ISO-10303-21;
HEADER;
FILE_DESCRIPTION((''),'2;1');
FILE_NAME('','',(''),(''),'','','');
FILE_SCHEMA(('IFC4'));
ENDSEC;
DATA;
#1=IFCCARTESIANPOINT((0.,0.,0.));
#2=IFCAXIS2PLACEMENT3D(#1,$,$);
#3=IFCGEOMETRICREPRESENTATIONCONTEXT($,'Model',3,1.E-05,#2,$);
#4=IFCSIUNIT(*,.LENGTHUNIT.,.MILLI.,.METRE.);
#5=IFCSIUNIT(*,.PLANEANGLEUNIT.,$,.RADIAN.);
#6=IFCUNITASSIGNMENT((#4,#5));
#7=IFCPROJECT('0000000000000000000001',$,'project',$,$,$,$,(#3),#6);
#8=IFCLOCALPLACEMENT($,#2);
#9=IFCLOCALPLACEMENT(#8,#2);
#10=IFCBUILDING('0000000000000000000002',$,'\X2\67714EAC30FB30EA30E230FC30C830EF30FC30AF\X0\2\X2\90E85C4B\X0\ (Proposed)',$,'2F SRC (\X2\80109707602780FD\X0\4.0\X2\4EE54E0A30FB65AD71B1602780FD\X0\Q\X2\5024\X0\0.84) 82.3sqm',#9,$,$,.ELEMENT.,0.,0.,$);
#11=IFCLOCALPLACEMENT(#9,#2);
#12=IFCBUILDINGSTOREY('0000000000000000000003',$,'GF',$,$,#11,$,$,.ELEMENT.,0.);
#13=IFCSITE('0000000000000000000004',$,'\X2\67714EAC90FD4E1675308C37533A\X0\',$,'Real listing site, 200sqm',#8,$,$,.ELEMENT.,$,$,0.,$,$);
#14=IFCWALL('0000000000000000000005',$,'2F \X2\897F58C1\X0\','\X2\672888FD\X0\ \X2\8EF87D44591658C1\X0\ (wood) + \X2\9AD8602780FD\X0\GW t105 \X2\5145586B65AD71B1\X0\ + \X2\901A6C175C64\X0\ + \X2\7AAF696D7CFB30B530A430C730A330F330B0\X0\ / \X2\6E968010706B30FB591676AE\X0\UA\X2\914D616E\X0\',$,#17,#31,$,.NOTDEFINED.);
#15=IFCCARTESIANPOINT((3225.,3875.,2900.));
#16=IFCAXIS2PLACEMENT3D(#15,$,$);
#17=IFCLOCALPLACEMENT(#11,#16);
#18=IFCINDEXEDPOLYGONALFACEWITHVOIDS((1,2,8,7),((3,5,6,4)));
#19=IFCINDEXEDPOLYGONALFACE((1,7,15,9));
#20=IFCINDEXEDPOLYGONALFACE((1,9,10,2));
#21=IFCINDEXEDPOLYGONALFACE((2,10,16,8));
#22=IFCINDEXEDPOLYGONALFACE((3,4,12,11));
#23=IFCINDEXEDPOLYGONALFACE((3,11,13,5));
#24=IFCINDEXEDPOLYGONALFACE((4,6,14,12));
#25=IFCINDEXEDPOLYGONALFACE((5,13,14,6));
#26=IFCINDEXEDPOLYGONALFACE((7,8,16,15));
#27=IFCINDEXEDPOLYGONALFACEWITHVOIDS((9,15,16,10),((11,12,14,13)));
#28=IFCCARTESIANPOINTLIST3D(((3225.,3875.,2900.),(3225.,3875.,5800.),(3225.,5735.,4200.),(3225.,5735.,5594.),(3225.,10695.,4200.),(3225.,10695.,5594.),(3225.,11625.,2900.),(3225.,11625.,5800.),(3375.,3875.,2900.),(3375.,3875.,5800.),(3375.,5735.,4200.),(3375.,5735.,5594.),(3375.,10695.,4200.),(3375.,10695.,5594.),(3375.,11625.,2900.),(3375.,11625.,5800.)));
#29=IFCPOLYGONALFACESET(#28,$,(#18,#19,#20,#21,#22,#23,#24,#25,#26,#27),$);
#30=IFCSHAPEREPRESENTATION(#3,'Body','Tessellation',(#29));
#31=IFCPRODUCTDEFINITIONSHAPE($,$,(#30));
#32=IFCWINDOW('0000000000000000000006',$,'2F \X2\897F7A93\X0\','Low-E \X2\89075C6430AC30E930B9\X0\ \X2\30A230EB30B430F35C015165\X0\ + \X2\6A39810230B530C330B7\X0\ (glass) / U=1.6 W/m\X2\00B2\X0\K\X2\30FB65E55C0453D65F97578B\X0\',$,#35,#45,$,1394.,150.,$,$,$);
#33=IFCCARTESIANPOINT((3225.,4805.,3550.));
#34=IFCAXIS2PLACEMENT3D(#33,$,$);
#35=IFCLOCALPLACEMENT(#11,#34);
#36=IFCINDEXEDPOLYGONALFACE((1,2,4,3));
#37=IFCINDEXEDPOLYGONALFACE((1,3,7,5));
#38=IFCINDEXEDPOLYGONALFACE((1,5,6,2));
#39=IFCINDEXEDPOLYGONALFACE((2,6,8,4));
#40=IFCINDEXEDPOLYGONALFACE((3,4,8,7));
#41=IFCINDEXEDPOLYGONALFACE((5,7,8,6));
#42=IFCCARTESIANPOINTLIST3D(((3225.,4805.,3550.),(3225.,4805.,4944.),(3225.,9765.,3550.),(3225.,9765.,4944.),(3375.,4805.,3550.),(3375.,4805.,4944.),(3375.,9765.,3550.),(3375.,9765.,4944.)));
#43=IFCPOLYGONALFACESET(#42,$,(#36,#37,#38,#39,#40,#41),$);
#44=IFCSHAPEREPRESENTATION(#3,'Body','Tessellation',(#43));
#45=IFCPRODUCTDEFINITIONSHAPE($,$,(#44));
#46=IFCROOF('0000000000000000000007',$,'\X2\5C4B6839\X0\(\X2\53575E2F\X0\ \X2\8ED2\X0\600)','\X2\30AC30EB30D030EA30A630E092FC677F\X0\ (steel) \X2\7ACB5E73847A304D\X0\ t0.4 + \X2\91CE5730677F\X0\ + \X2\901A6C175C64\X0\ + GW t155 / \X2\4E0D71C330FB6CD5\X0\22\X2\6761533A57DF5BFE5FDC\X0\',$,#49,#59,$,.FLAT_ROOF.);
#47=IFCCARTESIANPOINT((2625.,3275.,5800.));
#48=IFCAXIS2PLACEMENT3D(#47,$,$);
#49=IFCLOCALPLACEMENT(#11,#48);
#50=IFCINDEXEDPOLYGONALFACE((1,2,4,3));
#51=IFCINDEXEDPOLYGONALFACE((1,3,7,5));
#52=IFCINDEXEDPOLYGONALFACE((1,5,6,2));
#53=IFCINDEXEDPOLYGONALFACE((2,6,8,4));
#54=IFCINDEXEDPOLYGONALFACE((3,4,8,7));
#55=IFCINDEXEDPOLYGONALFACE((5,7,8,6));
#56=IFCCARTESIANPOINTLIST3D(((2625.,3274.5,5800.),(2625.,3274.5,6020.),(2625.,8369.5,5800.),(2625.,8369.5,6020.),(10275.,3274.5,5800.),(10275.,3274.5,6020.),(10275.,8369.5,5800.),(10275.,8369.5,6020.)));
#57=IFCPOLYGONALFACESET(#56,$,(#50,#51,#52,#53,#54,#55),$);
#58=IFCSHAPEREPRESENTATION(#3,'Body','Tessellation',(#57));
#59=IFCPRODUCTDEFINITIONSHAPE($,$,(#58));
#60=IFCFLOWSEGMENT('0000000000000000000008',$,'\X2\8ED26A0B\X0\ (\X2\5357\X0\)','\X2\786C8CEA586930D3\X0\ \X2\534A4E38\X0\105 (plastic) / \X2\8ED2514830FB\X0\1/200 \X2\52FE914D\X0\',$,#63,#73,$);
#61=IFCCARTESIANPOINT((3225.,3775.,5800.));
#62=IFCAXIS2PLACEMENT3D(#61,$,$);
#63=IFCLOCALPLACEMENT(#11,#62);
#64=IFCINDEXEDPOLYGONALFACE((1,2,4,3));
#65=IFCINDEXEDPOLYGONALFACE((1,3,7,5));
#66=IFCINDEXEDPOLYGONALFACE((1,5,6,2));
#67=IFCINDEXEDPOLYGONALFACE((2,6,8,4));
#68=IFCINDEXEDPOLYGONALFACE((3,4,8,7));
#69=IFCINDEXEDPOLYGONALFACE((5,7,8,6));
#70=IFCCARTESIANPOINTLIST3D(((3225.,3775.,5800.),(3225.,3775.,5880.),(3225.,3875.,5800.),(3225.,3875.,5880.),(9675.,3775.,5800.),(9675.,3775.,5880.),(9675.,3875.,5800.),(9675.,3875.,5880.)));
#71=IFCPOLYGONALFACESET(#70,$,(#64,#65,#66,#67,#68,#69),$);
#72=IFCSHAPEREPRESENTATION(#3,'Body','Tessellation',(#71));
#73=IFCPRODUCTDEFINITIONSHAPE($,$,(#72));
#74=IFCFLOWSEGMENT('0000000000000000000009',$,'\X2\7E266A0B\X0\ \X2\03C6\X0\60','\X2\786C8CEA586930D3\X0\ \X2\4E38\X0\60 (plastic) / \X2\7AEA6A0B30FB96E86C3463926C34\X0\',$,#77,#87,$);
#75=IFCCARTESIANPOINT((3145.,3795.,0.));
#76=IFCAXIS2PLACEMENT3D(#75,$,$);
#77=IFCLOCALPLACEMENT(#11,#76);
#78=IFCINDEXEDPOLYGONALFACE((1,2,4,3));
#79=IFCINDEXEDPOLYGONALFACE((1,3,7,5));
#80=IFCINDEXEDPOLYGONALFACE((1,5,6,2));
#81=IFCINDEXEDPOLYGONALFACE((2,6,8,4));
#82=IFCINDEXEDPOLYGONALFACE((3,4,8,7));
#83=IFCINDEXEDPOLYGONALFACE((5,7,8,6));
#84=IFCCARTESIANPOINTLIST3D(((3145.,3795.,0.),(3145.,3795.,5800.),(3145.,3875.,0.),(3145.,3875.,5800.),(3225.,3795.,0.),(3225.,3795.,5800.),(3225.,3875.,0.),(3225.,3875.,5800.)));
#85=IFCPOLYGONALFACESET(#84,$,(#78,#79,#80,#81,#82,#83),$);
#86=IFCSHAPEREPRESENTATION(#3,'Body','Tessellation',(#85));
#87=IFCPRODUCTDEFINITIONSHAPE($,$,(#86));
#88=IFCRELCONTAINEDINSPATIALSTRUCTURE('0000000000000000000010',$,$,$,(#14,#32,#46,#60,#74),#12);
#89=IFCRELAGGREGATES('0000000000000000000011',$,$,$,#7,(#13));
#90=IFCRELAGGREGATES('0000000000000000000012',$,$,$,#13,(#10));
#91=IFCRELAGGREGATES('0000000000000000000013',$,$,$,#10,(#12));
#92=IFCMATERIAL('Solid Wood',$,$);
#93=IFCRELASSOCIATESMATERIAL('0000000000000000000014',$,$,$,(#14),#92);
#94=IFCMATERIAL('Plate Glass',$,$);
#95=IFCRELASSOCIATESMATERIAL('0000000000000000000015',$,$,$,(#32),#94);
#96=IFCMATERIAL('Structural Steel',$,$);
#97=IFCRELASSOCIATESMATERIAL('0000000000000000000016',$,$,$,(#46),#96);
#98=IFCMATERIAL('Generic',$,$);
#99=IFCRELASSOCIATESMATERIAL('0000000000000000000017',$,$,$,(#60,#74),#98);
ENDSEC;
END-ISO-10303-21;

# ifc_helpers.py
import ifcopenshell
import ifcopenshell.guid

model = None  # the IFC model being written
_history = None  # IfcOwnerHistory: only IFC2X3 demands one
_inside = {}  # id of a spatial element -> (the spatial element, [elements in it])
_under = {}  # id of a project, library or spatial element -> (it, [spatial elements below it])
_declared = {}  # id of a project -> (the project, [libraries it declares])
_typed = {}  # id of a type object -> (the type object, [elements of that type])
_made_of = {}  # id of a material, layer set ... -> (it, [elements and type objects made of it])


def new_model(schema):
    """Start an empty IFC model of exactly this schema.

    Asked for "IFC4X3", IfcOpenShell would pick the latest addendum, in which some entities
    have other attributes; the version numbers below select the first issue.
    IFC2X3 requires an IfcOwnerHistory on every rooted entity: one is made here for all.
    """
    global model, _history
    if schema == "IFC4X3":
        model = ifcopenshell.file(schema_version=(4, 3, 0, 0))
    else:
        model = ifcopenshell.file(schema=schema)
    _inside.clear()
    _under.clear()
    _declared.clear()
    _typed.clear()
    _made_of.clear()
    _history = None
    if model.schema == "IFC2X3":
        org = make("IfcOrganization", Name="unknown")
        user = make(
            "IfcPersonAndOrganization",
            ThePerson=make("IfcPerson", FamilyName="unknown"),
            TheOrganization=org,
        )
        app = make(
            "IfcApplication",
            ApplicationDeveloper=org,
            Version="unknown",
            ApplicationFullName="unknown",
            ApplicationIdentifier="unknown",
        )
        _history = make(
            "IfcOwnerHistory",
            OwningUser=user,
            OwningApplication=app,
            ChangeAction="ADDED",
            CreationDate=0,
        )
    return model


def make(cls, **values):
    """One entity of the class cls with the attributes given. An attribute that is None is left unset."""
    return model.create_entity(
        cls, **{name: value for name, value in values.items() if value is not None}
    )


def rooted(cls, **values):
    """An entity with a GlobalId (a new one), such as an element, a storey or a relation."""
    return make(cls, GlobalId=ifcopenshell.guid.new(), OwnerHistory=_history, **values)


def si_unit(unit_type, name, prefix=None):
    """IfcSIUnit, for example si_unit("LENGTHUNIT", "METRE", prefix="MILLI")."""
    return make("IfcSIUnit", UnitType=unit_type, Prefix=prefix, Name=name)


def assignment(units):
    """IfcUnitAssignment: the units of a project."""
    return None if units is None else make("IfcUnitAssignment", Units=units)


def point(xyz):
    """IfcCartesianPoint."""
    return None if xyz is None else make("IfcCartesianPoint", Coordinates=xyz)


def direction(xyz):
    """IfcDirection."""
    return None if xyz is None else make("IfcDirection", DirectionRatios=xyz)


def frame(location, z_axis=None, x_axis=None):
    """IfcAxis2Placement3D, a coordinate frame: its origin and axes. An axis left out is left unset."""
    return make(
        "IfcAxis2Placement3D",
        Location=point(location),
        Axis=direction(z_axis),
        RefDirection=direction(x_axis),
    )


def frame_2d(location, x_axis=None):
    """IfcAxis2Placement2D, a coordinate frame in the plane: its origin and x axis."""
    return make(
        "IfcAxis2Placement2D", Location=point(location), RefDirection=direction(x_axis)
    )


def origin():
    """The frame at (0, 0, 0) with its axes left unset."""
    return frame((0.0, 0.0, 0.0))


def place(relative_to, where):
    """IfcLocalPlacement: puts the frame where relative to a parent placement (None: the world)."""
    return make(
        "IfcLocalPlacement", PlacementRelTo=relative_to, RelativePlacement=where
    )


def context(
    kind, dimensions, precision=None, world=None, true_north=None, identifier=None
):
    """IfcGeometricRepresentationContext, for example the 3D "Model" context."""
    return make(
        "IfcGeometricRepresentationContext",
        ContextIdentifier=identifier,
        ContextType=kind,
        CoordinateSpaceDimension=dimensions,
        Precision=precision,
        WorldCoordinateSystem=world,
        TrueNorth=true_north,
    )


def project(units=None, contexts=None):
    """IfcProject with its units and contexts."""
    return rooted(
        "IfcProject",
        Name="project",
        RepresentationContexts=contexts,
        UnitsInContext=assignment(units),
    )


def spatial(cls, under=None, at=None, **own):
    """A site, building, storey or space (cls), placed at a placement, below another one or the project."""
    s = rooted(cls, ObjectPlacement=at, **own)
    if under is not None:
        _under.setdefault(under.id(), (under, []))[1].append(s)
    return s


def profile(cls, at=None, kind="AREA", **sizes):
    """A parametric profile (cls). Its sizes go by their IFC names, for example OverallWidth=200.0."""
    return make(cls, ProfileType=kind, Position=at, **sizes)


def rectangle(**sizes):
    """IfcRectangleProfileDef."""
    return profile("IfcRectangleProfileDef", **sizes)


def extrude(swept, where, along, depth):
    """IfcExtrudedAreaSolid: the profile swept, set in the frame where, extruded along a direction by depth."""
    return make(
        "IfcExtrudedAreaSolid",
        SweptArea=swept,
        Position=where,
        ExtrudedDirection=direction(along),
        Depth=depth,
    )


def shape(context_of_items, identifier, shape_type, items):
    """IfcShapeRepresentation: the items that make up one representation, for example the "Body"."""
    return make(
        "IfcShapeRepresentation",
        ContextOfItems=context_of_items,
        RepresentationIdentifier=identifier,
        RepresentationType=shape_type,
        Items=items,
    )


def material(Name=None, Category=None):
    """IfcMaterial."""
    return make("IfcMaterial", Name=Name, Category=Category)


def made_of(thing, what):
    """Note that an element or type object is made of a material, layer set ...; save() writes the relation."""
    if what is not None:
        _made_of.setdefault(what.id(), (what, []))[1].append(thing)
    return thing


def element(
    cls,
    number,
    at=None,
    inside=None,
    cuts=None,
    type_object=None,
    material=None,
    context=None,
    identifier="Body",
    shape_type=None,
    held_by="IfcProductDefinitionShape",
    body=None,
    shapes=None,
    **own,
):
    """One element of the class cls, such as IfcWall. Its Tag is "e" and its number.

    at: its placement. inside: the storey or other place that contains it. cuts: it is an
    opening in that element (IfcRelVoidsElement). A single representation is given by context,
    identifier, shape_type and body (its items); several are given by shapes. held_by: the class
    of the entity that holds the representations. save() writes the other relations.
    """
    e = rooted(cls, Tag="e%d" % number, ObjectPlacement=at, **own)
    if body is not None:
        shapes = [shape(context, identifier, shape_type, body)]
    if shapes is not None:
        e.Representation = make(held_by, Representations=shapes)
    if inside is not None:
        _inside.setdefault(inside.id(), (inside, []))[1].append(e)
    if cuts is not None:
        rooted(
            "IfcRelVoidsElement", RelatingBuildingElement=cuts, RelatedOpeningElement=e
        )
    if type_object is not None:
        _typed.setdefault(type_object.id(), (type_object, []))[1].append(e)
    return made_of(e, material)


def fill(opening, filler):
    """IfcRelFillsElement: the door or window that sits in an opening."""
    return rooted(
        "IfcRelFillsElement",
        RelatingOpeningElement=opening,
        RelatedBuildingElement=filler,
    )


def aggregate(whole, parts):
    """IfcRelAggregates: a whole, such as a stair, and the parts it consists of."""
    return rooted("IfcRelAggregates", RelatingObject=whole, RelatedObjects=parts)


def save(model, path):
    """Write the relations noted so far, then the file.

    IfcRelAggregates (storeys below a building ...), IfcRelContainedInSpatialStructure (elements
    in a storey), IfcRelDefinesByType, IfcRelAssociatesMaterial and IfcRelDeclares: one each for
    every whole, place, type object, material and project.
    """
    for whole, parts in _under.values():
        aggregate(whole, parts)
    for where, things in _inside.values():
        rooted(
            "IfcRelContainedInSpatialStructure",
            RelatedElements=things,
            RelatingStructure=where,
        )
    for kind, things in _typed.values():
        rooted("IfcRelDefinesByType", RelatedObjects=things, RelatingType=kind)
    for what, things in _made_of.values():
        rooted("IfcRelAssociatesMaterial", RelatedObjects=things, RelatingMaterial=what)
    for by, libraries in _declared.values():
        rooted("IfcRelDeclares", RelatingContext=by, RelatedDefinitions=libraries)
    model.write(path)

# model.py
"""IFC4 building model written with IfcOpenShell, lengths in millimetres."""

from ifc_helpers import new_model, si_unit, frame, frame_2d, origin, place, context, project, spatial, rectangle, extrude, material, element, fill, save


model = new_model("IFC4")

# Units and contexts
model_context = context("Model", 3, precision=1e-05, world=origin())
ifc_project = project(units=[si_unit("LENGTHUNIT", "METRE", prefix="MILLI"), si_unit("PLANEANGLEUNIT", "RADIAN")], contexts=[model_context])

# Site, building, storey
site_placement = place(None, origin())
site = spatial("IfcSite", under=ifc_project, at=site_placement, Name="東京都世田谷区", ObjectType="Real listing site, 200sqm", CompositionType="ELEMENT", RefElevation=0.0)
building_placement = place(site_placement, origin())
building = spatial("IfcBuilding", under=site, at=building_placement, Name="東京・リモートワーク2部屋 (Proposed)", ObjectType="2F SRC (耐震性能4.0以上・断熱性能Q値0.84) 82.3sqm", CompositionType="ELEMENT", ElevationOfRefHeight=0.0, ElevationOfTerrain=0.0)
storey_placement = place(building_placement, origin())
storey = spatial("IfcBuildingStorey", under=building, at=storey_placement, Name="GF", CompositionType="ELEMENT", Elevation=0.0)

# Shared definitions
ifc_material_1 = material(Name="Solid Wood")

# Shared definitions
ifc_material_2 = material(Name="Plate Glass")

# Wall, opening, window
wall_1_placement = place(storey_placement, frame((3225.0, 3875.0, 2900.0)))
wall_1 = element("IfcWall", 1, at=wall_1_placement, inside=storey, material=ifc_material_1, Name="2F 西壁", Description="木製 軸組外壁 (wood) + 高性能GW t105 充填断熱 + 通気層 + 窯業系サイディング / 準耐火・外皮UA配慮", PredefinedType="NOTDEFINED", context=model_context, shape_type="SweptSolid", body=[
    extrude(rectangle(XDim=150.0, YDim=7750.0, at=frame_2d((75.0, 3875.0))), frame((3225.0, 3875.0, 2900.0)), (0.0, 0.0, 1.0), 2900.0),
])
opening_1_placement = place(storey_placement, frame((3225.0, 4805.0, 3550.0)))
opening_1 = element("IfcOpeningElement", 2, at=opening_1_placement, cuts=wall_1, PredefinedType="NOTDEFINED", context=model_context, shape_type="SweptSolid", body=[
    extrude(rectangle(XDim=150.0, YDim=4960.0, at=frame_2d((75.0, 2480.0))), frame((3225.0, 4805.0, 3550.0)), (0.0, 0.0, 1.0), 1394.0),
])
window_1_placement = place(storey_placement, frame((3225.0, 4805.0, 3550.0)))
window_1 = element("IfcWindow", 3, at=window_1_placement, inside=storey, material=ifc_material_2, Name="2F 西窓", Description="Low-E 複層ガラス アルゴン封入 + 樹脂サッシ (glass) / U=1.6 W/m²K・日射取得型", OverallHeight=1394.0, OverallWidth=150.0, context=model_context, shape_type="SweptSolid", body=[
    extrude(rectangle(XDim=150.0, YDim=4960.0, at=frame_2d((75.0, 2480.0))), frame((3225.0, 4805.0, 3550.0)), (0.0, 0.0, 1.0), 1394.0),
])
fill(opening_1, window_1)

# Roof
ifc_material_3 = material(Name="Structural Steel")
for number, where, name in (
    (4, (2625.0, 3275.0, 5800.0), "屋根(南帯 軒600)"),
):
    element("IfcRoof", number, at=place(storey_placement, frame(where)), inside=storey, material=ifc_material_3, Name=name, Description="ガルバリウム鋼板 (steel) 立平葺き t0.4 + 野地板 + 通気層 + GW t155 / 不燃・法22条区域対応", PredefinedType="FLAT_ROOF", context=model_context, shape_type="SweptSolid", body=[
        extrude(rectangle(XDim=7650.0, YDim=5095.0, at=frame_2d((3825.0, 2547.0))), frame((2625.0, 3275.0, 5800.0)), (0.0, 0.0, 1.0), 220.0),
    ])

# Flow segments
ifc_material_4 = material(Name="Generic")
flow_segment_1_placement = place(storey_placement, frame((3225.0, 3775.0, 5800.0)))
element("IfcFlowSegment", 5, at=flow_segment_1_placement, inside=storey, material=ifc_material_4, Name="軒樋 (南)", Description="硬質塩ビ 半丸105 (plastic) / 軒先・1/200 勾配", context=model_context, shape_type="SweptSolid", body=[
    extrude(rectangle(XDim=6450.0, YDim=100.0, at=frame_2d((3225.0, 50.0))), frame((3225.0, 3775.0, 5800.0)), (0.0, 0.0, 1.0), 80.0),
])
flow_segment_2_placement = place(storey_placement, frame((3145.0, 3795.0, 0.0)))
element("IfcFlowSegment", 6, at=flow_segment_2_placement, inside=storey, material=ifc_material_4, Name="縦樋 φ60", Description="硬質塩ビ 丸60 (plastic) / 竪樋・雨水排水", context=model_context, shape_type="SweptSolid", body=[
    extrude(rectangle(XDim=80.0, YDim=80.0, at=frame_2d((40.0, 40.0))), frame((3145.0, 3795.0, 0.0)), (0.0, 0.0, 1.0), 5800.0),
])

save(model, "model.ifc")
